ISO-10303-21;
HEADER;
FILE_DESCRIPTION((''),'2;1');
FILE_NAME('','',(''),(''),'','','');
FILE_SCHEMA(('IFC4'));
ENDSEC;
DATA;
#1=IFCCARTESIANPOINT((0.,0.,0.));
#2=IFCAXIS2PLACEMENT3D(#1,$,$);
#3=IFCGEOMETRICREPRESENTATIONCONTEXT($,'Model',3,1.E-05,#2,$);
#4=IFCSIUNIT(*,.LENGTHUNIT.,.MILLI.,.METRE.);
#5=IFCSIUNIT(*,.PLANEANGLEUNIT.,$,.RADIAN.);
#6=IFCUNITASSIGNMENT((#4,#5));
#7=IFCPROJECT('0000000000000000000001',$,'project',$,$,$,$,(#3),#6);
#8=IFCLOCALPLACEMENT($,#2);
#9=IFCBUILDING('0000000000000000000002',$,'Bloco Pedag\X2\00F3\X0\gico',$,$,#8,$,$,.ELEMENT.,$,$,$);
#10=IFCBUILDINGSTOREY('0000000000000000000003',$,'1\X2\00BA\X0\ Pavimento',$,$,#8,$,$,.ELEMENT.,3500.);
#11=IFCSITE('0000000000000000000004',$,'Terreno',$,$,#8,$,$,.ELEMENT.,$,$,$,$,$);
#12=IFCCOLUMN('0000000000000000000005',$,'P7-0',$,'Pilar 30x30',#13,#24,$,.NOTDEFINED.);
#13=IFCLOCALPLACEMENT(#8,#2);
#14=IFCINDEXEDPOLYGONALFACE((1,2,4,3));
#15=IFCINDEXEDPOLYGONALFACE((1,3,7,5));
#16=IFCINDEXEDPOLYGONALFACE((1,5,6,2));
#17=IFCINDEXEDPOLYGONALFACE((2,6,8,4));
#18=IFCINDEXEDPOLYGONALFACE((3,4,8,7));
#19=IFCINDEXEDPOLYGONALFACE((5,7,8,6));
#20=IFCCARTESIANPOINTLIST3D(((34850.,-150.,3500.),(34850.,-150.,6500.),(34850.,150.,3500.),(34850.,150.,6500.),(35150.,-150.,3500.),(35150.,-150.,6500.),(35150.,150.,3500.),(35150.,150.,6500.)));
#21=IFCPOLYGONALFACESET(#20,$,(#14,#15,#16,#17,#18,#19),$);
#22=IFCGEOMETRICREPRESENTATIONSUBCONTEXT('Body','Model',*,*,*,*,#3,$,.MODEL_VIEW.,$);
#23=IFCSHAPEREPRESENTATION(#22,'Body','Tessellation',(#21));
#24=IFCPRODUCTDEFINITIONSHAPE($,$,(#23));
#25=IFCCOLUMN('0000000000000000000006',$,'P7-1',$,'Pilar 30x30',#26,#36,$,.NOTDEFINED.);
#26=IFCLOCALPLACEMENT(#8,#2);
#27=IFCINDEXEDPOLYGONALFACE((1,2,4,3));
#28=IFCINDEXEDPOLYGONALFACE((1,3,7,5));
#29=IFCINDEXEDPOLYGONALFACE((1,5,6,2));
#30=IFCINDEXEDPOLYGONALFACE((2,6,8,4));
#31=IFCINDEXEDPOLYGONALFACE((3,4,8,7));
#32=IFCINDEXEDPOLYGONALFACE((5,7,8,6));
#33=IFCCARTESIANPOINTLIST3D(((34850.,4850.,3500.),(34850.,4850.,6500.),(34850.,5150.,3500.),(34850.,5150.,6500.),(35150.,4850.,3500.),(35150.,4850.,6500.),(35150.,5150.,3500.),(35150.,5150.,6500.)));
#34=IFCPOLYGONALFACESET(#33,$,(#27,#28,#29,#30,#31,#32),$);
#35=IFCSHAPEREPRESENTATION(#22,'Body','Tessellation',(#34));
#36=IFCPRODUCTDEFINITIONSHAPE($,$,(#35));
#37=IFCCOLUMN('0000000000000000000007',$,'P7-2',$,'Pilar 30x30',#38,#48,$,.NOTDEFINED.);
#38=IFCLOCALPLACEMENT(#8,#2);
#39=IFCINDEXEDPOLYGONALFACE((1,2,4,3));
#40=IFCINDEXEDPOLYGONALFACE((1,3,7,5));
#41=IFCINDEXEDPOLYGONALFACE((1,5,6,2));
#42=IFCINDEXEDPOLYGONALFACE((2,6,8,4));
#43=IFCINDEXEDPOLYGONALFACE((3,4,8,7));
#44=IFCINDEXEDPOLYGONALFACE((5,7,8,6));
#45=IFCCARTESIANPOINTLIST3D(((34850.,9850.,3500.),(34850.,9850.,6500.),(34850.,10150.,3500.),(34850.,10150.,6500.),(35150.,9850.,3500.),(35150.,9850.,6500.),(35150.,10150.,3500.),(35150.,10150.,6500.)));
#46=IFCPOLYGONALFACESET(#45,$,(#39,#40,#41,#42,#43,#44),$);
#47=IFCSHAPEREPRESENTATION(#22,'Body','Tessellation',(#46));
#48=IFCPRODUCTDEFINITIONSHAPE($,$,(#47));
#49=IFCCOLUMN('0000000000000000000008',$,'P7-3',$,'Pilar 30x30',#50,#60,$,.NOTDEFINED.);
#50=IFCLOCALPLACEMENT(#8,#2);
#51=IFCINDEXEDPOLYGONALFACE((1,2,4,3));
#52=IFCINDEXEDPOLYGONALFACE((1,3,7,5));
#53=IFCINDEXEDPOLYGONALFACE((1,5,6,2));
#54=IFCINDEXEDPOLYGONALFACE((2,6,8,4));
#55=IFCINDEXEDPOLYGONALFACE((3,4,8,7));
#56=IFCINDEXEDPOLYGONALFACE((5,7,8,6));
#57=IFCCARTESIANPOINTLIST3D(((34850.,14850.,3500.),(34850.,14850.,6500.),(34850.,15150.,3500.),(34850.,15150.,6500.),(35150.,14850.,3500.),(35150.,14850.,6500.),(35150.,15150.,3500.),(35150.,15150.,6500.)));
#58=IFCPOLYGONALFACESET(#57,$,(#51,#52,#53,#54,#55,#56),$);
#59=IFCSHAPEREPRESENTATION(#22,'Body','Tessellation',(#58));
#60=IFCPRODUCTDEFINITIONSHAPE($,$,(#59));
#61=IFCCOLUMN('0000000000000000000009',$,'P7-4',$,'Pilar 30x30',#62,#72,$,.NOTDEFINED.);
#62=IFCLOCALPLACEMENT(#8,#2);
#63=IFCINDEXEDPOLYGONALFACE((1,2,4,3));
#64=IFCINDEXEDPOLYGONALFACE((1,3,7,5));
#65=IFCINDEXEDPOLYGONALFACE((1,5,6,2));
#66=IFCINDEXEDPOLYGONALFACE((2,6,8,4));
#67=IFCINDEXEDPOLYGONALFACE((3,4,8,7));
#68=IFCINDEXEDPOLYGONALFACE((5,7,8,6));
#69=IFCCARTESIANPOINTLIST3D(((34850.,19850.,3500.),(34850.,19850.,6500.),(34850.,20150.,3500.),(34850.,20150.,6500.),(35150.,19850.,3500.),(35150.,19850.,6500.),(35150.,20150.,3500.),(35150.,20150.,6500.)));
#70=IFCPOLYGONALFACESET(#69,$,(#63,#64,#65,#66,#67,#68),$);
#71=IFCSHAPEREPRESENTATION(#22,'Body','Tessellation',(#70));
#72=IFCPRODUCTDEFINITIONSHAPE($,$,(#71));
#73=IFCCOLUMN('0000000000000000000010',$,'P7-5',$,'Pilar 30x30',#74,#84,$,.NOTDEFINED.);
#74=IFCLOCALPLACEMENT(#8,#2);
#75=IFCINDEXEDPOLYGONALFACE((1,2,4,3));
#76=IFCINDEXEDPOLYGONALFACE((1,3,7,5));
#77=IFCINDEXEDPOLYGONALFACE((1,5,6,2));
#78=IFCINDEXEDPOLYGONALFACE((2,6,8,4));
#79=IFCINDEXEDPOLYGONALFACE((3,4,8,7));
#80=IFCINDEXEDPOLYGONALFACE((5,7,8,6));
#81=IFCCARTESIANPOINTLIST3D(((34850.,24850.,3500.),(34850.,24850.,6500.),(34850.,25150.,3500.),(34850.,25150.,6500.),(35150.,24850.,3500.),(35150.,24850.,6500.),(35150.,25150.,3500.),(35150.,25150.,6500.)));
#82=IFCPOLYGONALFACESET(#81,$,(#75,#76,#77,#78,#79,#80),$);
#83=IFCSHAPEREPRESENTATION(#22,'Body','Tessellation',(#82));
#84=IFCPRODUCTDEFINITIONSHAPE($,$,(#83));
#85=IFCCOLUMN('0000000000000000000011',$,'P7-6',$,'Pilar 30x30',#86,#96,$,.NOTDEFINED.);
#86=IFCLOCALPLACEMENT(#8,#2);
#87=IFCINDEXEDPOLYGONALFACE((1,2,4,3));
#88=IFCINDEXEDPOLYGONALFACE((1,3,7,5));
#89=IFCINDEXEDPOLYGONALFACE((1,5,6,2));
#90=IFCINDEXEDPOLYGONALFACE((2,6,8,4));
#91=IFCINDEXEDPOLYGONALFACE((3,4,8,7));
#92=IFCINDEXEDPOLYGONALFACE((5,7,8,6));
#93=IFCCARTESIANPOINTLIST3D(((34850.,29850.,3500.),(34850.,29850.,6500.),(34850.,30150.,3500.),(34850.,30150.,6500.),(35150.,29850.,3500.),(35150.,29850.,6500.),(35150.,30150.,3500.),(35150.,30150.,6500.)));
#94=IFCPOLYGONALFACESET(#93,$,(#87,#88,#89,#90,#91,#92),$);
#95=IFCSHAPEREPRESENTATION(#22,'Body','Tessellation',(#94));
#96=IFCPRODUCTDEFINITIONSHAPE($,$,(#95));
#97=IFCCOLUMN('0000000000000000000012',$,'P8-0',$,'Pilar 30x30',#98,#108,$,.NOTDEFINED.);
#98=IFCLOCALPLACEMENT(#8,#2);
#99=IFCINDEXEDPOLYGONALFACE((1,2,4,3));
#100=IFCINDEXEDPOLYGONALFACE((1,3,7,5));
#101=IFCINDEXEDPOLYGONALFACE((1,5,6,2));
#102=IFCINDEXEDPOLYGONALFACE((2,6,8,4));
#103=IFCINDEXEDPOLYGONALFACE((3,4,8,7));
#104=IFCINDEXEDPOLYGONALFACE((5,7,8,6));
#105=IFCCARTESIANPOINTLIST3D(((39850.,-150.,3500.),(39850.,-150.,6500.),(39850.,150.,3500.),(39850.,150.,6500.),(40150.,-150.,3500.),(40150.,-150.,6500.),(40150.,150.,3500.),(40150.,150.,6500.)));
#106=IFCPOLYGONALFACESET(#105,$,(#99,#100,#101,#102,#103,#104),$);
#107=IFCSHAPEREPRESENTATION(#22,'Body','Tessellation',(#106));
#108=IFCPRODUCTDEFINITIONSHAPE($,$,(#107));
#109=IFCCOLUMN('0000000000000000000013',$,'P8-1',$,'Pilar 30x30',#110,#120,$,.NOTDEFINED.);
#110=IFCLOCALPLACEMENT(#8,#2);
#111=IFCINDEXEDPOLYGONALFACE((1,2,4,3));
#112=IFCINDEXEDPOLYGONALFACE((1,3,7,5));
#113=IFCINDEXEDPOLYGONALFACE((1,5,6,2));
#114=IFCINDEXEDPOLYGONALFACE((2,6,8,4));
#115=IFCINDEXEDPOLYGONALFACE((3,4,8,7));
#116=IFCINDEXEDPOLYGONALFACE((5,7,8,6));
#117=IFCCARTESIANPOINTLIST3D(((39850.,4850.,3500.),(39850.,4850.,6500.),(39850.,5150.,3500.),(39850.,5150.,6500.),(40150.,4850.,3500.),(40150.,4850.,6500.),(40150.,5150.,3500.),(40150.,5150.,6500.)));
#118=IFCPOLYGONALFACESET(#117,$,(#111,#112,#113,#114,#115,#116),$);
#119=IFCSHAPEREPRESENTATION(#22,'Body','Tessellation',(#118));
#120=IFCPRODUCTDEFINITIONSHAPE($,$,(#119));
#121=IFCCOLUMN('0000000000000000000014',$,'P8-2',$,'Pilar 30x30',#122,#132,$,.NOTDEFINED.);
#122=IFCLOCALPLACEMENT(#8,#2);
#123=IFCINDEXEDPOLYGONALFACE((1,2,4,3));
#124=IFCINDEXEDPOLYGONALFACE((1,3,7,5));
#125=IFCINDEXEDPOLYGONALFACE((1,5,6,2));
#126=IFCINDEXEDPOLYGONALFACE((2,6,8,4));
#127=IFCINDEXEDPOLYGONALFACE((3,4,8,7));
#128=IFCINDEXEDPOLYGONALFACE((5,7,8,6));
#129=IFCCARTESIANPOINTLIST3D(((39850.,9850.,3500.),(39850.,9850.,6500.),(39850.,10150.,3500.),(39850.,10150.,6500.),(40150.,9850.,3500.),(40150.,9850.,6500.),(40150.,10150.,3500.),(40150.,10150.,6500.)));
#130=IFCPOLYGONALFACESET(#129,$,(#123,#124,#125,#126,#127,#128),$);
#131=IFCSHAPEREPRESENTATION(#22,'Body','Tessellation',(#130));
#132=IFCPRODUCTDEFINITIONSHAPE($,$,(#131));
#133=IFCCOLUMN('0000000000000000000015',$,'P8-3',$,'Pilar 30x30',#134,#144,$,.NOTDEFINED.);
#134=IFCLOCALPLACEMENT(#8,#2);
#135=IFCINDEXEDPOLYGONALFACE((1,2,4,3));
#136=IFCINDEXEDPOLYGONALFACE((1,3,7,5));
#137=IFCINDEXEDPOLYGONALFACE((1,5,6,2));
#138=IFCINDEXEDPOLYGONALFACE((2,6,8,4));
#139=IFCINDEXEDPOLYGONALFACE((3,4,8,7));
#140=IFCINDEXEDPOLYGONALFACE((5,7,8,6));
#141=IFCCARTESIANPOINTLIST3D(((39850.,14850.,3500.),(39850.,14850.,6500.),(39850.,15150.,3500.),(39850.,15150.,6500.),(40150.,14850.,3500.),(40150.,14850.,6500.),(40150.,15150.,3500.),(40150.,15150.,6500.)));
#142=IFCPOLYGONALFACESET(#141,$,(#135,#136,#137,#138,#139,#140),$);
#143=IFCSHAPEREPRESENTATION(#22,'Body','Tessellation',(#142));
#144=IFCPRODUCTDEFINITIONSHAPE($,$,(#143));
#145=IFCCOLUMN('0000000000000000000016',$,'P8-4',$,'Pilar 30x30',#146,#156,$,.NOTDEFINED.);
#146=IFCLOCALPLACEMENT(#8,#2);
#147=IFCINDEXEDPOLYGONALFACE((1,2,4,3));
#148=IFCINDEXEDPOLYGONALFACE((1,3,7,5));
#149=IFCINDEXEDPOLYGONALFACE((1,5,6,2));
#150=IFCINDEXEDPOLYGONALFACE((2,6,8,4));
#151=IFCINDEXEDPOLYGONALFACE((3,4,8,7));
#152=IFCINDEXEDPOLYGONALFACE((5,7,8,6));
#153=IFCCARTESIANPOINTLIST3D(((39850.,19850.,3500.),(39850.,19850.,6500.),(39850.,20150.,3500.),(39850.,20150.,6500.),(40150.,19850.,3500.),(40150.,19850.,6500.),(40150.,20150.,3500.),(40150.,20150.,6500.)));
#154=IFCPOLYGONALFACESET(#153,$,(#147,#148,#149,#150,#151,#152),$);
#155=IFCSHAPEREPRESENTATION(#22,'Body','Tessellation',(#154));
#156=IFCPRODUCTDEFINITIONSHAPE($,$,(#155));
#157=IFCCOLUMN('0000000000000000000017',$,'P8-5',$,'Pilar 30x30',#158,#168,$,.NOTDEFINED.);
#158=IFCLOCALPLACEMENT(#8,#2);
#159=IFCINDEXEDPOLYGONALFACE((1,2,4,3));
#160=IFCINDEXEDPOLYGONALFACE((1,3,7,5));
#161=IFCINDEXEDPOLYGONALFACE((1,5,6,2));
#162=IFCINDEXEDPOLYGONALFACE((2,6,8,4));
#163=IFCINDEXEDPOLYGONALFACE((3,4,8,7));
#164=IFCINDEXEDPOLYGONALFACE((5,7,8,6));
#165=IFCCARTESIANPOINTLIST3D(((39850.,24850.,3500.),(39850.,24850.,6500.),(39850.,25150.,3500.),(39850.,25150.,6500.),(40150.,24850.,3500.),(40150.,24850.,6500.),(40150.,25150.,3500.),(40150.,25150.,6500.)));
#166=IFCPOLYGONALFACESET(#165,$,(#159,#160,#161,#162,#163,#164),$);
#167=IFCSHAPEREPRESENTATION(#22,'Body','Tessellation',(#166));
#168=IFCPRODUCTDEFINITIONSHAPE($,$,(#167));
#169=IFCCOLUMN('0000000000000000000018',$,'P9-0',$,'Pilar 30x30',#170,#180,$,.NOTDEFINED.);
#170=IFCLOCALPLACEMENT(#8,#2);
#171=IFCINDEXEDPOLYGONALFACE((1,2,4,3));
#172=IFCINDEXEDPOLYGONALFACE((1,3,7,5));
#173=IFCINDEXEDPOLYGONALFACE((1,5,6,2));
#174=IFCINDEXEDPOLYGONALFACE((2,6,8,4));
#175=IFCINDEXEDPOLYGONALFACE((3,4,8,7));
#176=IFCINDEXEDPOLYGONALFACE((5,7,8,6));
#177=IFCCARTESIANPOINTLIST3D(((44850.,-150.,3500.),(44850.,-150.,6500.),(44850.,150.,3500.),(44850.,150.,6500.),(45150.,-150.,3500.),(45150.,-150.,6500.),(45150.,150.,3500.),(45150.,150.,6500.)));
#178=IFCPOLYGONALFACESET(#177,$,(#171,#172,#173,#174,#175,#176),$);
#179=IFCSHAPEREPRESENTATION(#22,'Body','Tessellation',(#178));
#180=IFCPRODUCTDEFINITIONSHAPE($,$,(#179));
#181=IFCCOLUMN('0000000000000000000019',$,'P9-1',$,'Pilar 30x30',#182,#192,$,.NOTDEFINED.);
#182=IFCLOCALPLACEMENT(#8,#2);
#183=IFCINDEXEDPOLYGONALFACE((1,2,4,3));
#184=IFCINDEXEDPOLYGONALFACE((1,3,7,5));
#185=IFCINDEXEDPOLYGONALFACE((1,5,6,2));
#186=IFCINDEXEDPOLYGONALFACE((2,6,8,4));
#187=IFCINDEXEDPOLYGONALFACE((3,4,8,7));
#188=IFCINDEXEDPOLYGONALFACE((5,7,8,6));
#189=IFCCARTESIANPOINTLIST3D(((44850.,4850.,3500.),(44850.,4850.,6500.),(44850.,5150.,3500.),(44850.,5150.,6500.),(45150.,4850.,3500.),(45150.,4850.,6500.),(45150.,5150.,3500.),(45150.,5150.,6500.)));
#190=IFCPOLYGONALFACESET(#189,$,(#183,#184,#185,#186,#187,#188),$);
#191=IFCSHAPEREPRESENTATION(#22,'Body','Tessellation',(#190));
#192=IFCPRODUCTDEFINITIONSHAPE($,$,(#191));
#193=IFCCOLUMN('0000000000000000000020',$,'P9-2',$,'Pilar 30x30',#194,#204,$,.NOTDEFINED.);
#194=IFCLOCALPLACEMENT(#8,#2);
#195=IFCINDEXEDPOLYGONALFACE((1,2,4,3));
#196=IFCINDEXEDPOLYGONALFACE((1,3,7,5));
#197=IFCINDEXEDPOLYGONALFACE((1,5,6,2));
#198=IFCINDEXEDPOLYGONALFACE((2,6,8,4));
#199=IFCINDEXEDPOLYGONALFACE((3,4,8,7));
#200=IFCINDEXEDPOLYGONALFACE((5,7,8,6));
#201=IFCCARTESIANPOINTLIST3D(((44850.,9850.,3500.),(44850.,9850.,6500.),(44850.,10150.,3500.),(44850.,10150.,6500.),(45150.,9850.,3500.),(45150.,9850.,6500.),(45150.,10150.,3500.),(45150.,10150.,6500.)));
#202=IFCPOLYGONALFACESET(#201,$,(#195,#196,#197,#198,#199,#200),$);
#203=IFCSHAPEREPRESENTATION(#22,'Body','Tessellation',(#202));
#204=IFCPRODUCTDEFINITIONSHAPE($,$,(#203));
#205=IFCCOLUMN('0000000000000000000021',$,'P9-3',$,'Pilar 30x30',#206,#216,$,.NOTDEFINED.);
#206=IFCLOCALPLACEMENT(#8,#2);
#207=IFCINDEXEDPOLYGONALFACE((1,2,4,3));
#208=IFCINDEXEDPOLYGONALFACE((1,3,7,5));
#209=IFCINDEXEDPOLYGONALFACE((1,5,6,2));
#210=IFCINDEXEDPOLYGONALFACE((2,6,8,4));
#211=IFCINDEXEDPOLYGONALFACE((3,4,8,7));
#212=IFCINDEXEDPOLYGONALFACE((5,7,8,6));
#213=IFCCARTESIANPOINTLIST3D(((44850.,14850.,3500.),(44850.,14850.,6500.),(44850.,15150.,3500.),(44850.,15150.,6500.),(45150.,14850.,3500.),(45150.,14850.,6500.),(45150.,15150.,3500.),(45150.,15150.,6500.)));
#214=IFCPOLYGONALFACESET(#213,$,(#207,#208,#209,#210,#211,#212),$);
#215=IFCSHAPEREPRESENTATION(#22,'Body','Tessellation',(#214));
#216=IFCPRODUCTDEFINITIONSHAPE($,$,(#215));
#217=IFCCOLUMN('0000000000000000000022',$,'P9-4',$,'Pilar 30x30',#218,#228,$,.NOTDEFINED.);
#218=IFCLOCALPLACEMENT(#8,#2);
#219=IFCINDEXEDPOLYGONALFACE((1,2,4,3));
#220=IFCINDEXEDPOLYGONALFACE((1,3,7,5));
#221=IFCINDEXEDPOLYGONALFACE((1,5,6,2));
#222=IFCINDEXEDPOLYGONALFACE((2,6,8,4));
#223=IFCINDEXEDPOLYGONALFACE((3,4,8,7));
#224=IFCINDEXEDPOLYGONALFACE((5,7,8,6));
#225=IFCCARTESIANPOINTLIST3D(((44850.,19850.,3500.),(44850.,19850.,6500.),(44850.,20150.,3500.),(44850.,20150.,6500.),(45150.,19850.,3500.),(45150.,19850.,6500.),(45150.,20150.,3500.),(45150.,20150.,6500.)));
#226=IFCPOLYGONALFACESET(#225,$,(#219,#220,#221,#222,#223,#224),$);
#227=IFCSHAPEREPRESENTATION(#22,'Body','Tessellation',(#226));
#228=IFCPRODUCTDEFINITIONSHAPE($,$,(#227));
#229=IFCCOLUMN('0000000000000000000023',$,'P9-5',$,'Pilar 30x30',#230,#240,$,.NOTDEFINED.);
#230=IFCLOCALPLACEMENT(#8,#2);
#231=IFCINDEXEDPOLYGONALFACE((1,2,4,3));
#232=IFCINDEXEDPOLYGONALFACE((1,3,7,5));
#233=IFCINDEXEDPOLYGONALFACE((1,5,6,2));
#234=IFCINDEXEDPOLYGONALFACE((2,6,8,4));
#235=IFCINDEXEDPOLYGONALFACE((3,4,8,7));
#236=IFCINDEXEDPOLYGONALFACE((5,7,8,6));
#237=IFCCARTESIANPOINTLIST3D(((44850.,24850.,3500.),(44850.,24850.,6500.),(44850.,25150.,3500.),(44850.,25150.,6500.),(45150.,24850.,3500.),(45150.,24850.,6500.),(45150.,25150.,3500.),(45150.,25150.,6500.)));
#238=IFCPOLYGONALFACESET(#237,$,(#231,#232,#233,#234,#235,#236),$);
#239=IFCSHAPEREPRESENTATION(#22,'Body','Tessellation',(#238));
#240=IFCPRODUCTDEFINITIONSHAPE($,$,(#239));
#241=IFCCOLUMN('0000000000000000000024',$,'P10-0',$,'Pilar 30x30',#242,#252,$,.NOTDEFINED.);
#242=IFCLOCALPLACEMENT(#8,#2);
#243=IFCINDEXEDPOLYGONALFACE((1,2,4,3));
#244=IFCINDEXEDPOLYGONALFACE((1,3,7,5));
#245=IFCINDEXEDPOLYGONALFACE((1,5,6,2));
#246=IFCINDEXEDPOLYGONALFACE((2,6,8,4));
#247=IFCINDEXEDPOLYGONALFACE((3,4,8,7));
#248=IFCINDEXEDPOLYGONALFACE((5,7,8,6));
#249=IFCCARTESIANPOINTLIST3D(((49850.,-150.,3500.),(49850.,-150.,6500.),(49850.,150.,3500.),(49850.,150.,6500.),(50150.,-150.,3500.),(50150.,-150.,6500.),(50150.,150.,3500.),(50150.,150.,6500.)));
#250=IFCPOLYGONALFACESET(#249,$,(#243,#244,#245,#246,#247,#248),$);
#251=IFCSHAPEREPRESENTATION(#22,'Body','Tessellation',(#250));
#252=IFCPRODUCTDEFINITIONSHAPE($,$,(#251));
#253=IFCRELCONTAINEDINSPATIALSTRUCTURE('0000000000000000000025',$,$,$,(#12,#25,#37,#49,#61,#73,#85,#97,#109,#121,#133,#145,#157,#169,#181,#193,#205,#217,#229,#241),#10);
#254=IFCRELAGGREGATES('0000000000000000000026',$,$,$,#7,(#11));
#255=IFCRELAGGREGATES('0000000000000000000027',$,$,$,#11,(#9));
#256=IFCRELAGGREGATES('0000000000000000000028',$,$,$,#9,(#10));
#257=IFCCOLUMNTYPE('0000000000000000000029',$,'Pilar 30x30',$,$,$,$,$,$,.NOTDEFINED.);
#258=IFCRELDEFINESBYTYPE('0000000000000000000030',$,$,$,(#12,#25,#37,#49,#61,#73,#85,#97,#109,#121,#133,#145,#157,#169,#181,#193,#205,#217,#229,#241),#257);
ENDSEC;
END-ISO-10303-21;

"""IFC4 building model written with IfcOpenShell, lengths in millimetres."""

from ifc_helpers import new_model, si_unit, frame, origin, origin_2d, place, context, subcontext, project, spatial, rectangle, extrude, type_object, element, save


model = new_model("IFC4")

# Units and contexts
model_context = context("Model", 3, precision=1e-05, world=origin())
body_context = subcontext(model_context, "Body", "Model", "MODEL_VIEW")
ifc_project = project(units=[si_unit("LENGTHUNIT", "METRE", prefix="MILLI"), si_unit("PLANEANGLEUNIT", "RADIAN")], contexts=[model_context])

# Site, building, storey
placement = place(None, origin())
site = spatial("IfcSite", under=ifc_project, at=placement, Name="Terreno", CompositionType="ELEMENT")
building = spatial("IfcBuilding", under=site, at=placement, Name="Bloco Pedagógico", CompositionType="ELEMENT")
storey = spatial("IfcBuildingStorey", under=building, at=placement, Name="1º Pavimento", CompositionType="ELEMENT", Elevation=3500.0)

# Columns
column_type = type_object("IfcColumnType", Name="Pilar 30x30", PredefinedType="NOTDEFINED")
for number, where, z_axis, x_axis, name in (
    (1, (35000.0, 0.0, 3500.0), (0.0, 0.0, 1.0), (1.0, 0.0, 0.0), "P7-0"),
    (2, (35000.0, 5000.0, 3500.0), (0.0, 0.0, 1.0), (1.0, 0.0, 0.0), "P7-1"),
    (3, (35000.0, 10000.0, 3500.0), (0.0, 0.0, 1.0), (1.0, 0.0, 0.0), "P7-2"),
    (4, (35000.0, 15000.0, 3500.0), (0.0, 0.0, 1.0), (1.0, 0.0, 0.0), "P7-3"),
    (5, (35000.0, 20000.0, 3500.0), (0.0, 0.0, 1.0), (1.0, 0.0, 0.0), "P7-4"),
    (6, (35000.0, 25000.0, 3500.0), (0.0, 0.0, 1.0), (1.0, 0.0, 0.0), "P7-5"),
    (7, (35000.0, 30000.0, 3500.0), (0.0, 0.0, 1.0), (1.0, 0.0, 0.0), "P7-6"),
    (8, (40000.0, 0.0, 3500.0), (0.0, 0.0, 1.0), (1.0, 0.0, 0.0), "P8-0"),
    (9, (40000.0, 5000.0, 3500.0), (0.0, 0.0, 1.0), (1.0, 0.0, 0.0), "P8-1"),
    (10, (40000.0, 10000.0, 3500.0), (0.0, 0.0, 1.0), (1.0, 0.0, 0.0), "P8-2"),
    (11, (40000.0, 15000.0, 3500.0), (0.0, 0.0, 1.0), (1.0, 0.0, 0.0), "P8-3"),
    (12, (40000.0, 20000.0, 3500.0), (0.0, 0.0, 1.0), (1.0, 0.0, 0.0), "P8-4"),
    (13, (40000.0, 25000.0, 3500.0), (0.0, 0.0, 1.0), (1.0, 0.0, 0.0), "P8-5"),
    (14, (45000.0, 0.0, 3500.0), (0.0, 0.0, 1.0), (1.0, 0.0, 0.0), "P9-0"),
    (15, (45000.0, 5000.0, 3500.0), (0.0, 0.0, 1.0), (1.0, 0.0, 0.0), "P9-1"),
    (16, (45000.0, 10000.0, 3500.0), (0.0, 0.0, 1.0), (1.0, 0.0, 0.0), "P9-2"),
    (17, (45000.0, 15000.0, 3500.0), (0.0, 0.0, 1.0), (1.0, 0.0, 0.0), "P9-3"),
    (18, (45000.0, 20000.0, 3500.0), (0.0, 0.0, 1.0), (1.0, 0.0, 0.0), "P9-4"),
    (19, (45000.0, 25000.0, 3500.0), (0.0, 0.0, 1.0), (1.0, 0.0, 0.0), "P9-5"),
    (20, (50000.0, 0.0, 3500.0), (0.0, 0.0, 1.0), (1.0, 0.0, 0.0), "P10-0"),
):
    element("IfcColumn", number, at=place(None, frame(where, z_axis=z_axis, x_axis=x_axis)), inside=storey, type_object=column_type, Name=name, ObjectType="Pilar 30x30", PredefinedType="NOTDEFINED", context=body_context, shape_type="SweptSolid", body=[
        extrude(rectangle(XDim=300.0, YDim=300.0, at=origin_2d()), None, (0.0, 0.0, 1.0), 3000.0),
    ])

save(model, "model.ifc")
